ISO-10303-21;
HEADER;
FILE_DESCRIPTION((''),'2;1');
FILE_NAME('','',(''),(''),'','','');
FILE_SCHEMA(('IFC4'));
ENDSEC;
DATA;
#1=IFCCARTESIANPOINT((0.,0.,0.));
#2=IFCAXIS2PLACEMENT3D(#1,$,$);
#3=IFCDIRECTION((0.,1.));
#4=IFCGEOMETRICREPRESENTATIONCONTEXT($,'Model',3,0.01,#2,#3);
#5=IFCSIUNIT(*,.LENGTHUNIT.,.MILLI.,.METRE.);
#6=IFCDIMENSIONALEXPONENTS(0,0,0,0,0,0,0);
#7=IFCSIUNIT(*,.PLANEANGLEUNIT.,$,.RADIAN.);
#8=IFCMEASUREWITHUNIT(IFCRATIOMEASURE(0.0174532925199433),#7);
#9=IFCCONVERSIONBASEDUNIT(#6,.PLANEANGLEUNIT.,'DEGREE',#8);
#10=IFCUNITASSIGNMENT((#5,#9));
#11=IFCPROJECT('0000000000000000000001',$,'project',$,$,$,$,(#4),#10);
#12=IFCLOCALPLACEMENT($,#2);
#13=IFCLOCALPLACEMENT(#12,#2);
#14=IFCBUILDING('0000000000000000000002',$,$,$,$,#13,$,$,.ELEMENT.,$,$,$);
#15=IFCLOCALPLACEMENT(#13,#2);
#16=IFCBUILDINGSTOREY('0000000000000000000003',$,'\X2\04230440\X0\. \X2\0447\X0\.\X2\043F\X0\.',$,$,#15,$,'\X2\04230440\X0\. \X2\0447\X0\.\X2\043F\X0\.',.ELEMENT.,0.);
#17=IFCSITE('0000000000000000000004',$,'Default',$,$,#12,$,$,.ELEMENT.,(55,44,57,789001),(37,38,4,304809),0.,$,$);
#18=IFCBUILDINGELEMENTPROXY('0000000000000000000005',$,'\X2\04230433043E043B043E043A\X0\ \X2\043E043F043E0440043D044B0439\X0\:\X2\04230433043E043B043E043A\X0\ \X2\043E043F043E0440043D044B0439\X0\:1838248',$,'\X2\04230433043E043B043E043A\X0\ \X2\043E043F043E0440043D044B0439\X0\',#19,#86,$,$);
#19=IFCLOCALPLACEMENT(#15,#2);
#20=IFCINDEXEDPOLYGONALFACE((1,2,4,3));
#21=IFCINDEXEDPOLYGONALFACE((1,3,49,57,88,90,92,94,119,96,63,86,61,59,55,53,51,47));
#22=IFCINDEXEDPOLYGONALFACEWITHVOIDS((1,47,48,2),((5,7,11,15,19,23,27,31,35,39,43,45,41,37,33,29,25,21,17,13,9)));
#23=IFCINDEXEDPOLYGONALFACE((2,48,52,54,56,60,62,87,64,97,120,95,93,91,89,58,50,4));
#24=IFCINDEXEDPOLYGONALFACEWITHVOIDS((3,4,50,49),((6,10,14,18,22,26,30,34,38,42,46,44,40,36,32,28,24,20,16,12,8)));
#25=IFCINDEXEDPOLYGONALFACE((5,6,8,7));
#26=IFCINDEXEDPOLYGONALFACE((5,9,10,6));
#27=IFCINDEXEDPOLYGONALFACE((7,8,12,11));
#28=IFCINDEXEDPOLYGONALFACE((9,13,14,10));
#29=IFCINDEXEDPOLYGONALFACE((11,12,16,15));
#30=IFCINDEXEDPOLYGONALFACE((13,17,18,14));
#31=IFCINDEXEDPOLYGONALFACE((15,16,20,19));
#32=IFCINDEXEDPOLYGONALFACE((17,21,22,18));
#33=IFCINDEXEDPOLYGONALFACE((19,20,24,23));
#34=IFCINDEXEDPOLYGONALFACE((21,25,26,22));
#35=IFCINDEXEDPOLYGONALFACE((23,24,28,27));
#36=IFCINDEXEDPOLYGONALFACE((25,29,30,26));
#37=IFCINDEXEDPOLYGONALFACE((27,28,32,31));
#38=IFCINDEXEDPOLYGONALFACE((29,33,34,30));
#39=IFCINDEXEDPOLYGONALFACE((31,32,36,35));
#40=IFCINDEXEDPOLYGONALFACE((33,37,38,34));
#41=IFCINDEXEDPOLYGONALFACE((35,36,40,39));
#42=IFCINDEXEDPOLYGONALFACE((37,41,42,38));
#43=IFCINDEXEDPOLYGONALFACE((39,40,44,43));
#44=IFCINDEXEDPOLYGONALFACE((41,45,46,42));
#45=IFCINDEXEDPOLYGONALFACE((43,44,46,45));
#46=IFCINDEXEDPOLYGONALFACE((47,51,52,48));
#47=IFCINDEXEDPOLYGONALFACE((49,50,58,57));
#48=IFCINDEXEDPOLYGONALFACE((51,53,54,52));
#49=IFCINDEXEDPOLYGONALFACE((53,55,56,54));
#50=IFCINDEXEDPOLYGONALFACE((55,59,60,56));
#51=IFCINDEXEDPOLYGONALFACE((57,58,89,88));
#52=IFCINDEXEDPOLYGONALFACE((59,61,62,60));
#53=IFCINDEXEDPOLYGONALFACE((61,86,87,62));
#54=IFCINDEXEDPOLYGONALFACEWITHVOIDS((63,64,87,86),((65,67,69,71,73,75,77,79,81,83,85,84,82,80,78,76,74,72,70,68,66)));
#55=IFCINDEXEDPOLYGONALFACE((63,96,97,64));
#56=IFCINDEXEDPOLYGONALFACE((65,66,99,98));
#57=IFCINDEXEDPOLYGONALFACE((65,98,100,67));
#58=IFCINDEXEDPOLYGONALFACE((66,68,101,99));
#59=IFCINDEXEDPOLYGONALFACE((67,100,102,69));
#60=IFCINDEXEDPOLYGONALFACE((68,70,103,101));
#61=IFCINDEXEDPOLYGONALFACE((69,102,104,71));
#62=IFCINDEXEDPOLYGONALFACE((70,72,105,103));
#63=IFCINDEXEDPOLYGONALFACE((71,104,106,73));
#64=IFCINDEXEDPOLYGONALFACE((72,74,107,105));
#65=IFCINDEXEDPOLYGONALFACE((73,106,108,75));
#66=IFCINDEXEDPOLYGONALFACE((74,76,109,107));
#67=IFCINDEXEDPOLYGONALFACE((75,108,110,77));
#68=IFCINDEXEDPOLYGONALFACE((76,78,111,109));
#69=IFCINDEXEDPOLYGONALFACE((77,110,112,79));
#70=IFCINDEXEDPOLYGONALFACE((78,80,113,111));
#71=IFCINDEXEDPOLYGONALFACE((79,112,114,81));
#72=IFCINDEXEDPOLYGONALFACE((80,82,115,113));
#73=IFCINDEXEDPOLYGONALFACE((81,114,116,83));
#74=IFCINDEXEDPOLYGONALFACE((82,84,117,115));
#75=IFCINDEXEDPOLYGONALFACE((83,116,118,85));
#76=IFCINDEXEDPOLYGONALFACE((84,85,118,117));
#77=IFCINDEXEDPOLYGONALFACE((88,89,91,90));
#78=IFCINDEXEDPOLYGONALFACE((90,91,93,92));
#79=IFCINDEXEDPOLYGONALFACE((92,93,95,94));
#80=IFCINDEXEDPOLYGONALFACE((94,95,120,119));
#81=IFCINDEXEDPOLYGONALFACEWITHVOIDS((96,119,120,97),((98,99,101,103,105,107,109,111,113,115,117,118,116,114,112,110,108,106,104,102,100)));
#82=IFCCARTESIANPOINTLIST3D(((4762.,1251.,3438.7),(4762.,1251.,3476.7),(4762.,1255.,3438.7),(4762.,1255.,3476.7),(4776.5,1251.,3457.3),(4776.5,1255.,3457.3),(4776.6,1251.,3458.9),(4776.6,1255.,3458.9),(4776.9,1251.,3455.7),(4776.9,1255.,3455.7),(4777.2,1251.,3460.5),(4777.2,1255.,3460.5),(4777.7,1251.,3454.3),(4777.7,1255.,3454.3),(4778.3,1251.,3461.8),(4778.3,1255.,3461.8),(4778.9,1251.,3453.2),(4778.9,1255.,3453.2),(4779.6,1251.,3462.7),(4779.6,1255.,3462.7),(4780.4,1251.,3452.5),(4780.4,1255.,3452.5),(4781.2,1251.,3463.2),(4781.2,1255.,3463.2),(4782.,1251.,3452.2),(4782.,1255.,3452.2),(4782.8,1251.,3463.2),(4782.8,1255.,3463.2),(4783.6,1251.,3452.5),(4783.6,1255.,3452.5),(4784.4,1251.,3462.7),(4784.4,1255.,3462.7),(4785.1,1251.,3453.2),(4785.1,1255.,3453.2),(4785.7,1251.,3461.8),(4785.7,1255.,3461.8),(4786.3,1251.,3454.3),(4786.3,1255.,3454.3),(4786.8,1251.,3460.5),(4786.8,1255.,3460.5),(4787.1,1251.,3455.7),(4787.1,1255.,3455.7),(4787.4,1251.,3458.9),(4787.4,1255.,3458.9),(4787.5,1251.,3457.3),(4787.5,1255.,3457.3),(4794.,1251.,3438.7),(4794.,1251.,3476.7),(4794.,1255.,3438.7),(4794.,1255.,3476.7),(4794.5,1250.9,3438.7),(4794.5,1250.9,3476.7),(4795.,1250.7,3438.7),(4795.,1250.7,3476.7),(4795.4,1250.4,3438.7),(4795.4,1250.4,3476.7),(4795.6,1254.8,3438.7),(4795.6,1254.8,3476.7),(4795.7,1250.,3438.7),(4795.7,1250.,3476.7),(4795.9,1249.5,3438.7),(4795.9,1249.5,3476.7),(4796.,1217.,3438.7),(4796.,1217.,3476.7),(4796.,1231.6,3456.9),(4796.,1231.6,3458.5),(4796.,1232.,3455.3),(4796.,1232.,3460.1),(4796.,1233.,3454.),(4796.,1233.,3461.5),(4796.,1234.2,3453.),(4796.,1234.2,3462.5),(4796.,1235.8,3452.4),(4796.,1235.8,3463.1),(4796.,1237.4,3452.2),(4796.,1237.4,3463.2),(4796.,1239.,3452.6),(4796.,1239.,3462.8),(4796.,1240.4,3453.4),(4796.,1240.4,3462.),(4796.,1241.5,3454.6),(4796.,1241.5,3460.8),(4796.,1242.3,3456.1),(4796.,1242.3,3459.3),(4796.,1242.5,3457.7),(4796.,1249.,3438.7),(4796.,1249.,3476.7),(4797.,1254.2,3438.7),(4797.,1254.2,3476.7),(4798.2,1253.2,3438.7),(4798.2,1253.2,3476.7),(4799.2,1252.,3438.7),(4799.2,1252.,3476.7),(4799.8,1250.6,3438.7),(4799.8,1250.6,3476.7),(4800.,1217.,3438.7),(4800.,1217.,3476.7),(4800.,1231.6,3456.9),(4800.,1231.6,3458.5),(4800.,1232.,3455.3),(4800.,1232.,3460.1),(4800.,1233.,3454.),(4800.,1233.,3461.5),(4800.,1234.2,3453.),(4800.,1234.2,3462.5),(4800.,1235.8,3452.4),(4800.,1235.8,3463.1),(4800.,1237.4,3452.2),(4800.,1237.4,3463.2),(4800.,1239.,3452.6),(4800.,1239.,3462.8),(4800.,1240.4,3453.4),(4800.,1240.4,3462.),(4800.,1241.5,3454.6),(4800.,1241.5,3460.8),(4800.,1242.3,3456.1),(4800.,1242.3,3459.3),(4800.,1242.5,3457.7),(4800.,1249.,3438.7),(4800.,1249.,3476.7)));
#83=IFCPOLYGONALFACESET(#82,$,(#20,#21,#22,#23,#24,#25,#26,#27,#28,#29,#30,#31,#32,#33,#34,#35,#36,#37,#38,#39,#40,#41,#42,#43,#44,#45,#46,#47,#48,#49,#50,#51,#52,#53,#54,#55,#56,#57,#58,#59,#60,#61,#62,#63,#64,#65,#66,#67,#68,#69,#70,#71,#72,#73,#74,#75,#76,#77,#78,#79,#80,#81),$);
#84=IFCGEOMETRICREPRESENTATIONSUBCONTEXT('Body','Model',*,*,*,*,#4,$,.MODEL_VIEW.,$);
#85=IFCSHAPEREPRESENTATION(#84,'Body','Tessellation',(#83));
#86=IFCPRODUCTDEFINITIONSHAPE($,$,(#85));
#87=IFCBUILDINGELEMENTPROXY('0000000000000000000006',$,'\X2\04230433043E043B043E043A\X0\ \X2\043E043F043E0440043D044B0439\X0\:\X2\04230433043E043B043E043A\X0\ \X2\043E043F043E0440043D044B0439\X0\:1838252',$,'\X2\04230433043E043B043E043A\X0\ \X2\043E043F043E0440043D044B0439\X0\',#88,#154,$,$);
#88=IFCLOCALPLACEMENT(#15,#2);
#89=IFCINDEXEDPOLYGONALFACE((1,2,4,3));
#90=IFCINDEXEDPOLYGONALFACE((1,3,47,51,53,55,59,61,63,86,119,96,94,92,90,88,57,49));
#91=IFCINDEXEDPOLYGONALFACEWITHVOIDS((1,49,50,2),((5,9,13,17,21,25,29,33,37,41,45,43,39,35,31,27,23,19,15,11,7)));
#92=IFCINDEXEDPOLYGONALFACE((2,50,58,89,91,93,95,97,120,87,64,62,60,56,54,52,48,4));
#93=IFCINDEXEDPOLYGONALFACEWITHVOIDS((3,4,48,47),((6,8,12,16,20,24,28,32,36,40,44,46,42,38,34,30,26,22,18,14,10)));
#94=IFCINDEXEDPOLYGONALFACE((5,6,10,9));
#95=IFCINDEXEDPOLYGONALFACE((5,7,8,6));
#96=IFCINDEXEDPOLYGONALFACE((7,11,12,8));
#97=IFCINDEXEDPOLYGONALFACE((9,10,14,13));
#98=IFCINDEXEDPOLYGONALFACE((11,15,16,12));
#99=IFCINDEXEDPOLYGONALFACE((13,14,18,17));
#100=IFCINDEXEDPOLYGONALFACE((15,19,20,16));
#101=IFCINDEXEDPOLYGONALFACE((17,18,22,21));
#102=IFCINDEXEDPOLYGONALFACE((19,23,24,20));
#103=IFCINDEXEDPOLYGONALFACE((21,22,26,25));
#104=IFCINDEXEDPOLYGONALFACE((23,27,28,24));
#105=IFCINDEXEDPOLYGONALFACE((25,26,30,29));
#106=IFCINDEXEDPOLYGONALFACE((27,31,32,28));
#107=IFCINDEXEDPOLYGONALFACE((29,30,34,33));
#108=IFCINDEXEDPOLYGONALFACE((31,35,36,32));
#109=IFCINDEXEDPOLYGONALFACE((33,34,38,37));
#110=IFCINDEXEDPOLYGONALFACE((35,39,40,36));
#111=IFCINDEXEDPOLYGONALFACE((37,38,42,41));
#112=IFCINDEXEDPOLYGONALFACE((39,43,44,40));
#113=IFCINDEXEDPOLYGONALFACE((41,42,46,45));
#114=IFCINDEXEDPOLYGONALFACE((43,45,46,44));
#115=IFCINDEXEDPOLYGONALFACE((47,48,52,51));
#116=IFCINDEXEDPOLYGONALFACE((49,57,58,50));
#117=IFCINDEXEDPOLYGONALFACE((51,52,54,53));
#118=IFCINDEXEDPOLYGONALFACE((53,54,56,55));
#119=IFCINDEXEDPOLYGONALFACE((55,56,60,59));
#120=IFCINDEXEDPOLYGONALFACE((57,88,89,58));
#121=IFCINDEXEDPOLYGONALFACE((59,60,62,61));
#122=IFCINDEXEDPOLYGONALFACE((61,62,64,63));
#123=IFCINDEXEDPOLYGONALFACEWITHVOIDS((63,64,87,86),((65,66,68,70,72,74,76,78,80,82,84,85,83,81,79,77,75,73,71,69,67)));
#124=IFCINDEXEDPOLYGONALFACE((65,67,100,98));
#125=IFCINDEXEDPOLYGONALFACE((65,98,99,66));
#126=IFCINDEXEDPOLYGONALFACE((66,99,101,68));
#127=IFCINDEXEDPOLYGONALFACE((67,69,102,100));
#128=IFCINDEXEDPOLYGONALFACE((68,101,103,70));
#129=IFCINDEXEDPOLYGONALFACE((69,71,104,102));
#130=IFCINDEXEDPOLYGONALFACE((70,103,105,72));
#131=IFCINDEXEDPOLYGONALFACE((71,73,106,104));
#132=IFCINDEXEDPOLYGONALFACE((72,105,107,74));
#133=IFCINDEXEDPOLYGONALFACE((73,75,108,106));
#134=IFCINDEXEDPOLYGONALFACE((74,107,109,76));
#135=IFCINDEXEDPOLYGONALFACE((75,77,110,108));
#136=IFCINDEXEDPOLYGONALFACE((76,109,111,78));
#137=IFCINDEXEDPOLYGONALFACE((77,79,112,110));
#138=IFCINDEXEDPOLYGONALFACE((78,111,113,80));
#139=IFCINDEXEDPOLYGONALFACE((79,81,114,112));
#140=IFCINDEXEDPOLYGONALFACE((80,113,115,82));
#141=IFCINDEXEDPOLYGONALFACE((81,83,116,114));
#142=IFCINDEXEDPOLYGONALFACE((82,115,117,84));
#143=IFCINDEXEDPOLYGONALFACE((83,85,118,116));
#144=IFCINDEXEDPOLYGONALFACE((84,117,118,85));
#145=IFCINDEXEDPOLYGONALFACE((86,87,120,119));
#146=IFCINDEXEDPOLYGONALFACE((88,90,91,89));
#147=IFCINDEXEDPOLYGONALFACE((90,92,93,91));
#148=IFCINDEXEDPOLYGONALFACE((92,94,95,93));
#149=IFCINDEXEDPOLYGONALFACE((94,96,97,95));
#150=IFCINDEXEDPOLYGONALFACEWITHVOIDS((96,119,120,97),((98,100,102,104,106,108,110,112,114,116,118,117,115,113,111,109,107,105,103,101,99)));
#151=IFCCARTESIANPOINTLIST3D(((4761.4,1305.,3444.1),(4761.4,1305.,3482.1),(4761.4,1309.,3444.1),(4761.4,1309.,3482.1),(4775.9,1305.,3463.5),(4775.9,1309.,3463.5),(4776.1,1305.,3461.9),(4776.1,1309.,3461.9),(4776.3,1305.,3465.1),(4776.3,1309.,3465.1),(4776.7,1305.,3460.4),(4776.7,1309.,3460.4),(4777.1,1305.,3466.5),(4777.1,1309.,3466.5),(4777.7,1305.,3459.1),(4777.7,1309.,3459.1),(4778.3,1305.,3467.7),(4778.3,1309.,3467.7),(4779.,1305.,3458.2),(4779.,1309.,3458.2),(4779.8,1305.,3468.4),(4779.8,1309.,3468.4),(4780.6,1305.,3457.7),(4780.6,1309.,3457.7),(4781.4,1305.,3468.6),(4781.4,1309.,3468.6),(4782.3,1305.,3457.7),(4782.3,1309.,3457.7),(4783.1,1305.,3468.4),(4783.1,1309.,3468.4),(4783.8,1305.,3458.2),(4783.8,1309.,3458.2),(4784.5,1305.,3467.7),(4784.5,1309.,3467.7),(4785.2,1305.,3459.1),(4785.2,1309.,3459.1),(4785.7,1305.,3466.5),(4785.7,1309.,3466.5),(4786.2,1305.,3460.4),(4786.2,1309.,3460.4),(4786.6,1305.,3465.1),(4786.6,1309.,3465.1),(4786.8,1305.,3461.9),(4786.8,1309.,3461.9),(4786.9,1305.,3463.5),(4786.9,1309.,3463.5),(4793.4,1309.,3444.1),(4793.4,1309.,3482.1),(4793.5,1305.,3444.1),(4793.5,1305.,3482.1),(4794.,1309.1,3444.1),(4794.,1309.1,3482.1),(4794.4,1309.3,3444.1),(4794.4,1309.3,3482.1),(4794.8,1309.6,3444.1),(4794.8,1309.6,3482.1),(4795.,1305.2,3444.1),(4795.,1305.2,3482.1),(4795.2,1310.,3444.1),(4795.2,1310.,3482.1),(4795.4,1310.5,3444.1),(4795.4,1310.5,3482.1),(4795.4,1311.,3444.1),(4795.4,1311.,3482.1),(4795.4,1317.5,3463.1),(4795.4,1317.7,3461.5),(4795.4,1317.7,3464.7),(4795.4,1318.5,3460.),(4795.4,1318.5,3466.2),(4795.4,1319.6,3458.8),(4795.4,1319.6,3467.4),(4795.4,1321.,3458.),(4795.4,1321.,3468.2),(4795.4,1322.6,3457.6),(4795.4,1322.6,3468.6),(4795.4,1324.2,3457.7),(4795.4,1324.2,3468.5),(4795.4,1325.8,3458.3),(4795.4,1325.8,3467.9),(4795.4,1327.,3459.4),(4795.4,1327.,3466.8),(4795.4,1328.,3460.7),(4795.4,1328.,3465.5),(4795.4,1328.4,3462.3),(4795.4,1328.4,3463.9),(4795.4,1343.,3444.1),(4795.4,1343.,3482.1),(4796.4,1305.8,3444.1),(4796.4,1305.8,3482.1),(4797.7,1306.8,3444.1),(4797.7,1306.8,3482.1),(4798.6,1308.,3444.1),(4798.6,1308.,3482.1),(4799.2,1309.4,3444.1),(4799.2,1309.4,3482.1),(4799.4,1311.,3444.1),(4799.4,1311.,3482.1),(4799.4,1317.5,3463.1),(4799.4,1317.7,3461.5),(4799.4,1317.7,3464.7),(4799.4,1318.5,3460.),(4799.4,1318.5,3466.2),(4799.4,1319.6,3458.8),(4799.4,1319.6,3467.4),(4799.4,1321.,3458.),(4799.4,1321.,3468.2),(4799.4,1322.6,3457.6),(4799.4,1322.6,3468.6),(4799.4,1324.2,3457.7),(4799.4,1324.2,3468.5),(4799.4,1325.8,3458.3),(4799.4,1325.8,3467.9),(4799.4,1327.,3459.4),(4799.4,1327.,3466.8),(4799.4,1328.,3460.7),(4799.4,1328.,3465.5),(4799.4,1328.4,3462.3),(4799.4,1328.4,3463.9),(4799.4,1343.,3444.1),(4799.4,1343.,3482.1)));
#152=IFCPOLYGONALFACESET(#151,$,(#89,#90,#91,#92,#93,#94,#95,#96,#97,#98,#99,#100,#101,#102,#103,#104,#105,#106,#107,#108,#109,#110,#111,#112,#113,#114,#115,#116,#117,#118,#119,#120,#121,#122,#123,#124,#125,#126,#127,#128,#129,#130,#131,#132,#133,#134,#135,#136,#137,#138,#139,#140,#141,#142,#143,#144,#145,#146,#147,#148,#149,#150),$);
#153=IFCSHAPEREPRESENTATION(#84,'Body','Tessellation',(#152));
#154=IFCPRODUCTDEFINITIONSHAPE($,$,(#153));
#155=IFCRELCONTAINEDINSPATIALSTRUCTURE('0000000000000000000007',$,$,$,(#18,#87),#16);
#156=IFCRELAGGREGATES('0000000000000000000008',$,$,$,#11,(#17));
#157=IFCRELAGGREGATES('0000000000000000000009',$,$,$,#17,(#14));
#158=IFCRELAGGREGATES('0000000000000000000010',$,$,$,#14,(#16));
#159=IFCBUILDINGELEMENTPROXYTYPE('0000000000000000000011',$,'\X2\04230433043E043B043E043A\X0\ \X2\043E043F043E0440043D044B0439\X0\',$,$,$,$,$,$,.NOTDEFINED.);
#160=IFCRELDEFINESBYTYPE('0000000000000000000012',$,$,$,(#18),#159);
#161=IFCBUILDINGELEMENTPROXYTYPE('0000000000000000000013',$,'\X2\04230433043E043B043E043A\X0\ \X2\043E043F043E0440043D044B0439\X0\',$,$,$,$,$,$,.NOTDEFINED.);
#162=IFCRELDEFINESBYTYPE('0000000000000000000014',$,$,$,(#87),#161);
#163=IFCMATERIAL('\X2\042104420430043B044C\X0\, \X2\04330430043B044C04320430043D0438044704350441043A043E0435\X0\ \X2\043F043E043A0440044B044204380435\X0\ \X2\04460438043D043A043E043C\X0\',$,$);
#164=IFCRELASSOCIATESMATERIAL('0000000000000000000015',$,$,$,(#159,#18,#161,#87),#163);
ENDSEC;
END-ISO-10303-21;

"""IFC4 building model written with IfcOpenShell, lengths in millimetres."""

from ifc_helpers import new_model, entity, si_unit, converted_unit, direction, frame, frame_2d, origin, place, context, subcontext, project, spatial, polyline, circle_curve, parameter, trimmed, segment, composite_curve, circle, outline, extrude, source, transform, mapped, material, type_object, type_shapes, element, save


model = new_model("IFC4")

# Units and contexts
model_context = context("Model", 3, precision=0.01, world=origin(), true_north=direction((0.0, 1.0)))
body_context = subcontext(model_context, "Body", "Model", "MODEL_VIEW")
ifc_project = project(units=[si_unit("LENGTHUNIT", "METRE", prefix="MILLI"), converted_unit("PLANEANGLEUNIT", "DEGREE", entity("IfcRatioMeasure", 0.0174532925199433), si_unit("PLANEANGLEUNIT", "RADIAN"), dimensions=[0, 0, 0, 0, 0, 0, 0])], contexts=[model_context])

# Site, building, storey
site_placement = place(None, origin())
site = spatial("IfcSite", under=ifc_project, at=site_placement, Name="Default", CompositionType="ELEMENT", RefLatitude=(55, 44, 57, 789001), RefLongitude=(37, 38, 4, 304809), RefElevation=0.0)
building_placement = place(site_placement, origin())
building = spatial("IfcBuilding", under=site, at=building_placement, CompositionType="ELEMENT")
storey_placement = place(building_placement, origin())
storey = spatial("IfcBuildingStorey", under=building, at=storey_placement, Name="Ур. ч.п.", LongName="Ур. ч.п.", CompositionType="ELEMENT", Elevation=0.0)

# Building element proxies, openings
ifc_material = material(Name="Сталь, гальваническое покрытие цинком")
building_element_proxy_type_1 = type_object("IfcBuildingElementProxyType", Name="Уголок опорный", material=ifc_material)
shared_shape_1 = source(origin(), body_context, "Body", "SweptSolid", [
    extrude(outline(composite_curve([segment(polyline([(-6.0, -12.0), (26.0, -12.0)]), True, "CONTINUOUS"), segment(polyline([(26.0, -12.0), (26.0, -8.0)]), True, "CONTINUOUS"), segment(polyline([(26.0, -8.0), (-6.0, -8.0)]), True, "CONTINUOUS"), segment(trimmed(circle_curve(frame_2d((-6.0, -6.0), x_axis=(0.0, -1.0)), 2.0), [parameter(270.0)], [parameter(0.0)], True, "PARAMETER"), False, "CONTINUOUS"), segment(polyline([(-8.0, -6.0), (-8.0, 26.0)]), True, "CONTINUOUS"), segment(polyline([(-8.0, 26.0), (-12.0, 26.0)]), True, "CONTINUOUS"), segment(polyline([(-12.0, 26.0), (-12.0, -6.0)]), True, "CONTINUOUS"), segment(trimmed(circle_curve(frame_2d((-6.0, -6.0), x_axis=(0.0, -1.0)), 6.0), [parameter(270.0)], [parameter(360.0)], True, "PARAMETER"), True, "CONTINUOUS")], self_intersect=False)), frame((12.0, -19.0, 12.0), z_axis=(0.0, 1.0, 0.0), x_axis=(0.0, 0.0, 1.0)), (0.0, 0.0, 1.0), 38.0),
])
type_shapes(building_element_proxy_type_1, [shared_shape_1])
proxy_1_placement = place(storey_placement, frame((4800.0, 1255.0, 3457.7), z_axis=(0.0, -1.0, 0.0), x_axis=(-1.0, 0.0, 0.0)))
proxy_1 = element("IfcBuildingElementProxy", 1, at=proxy_1_placement, inside=storey, type_object=building_element_proxy_type_1, material=ifc_material, Name="Уголок опорный:Уголок опорный:1838248", ObjectType="Уголок опорный", context=body_context, shape_type="MappedRepresentation", body=[
    mapped(shared_shape_1, transform((0.0, 0.0, 0.0), scale=1.0)),
])
opening_1_placement = place(storey_placement, frame((4800.0, 1255.0, 3457.7)))
element("IfcOpeningElement", 2, at=opening_1_placement, cuts=proxy_1, ObjectType="Opening", PredefinedType="OPENING", context=body_context, shape_type="SweptSolid", body=[
    extrude(circle(Radius=5.5, at=frame_2d((0.0, 0.0), x_axis=(1.0, 0.0))), frame((-4.0, -18.0, 0.0), z_axis=(1.0, 0.0, 0.0), x_axis=(0.0, 1.0, 0.0)), (0.0, 0.0, 1.0), 4.0),
])
opening_2_placement = place(storey_placement, frame((4800.0, 1255.0, 3457.7)))
element("IfcOpeningElement", 3, at=opening_2_placement, cuts=proxy_1, ObjectType="Opening", PredefinedType="OPENING", context=body_context, shape_type="SweptSolid", body=[
    extrude(circle(Radius=5.5, at=frame_2d((0.0, 0.0), x_axis=(1.0, 0.0))), frame((-18.0, 0.0, 0.0), z_axis=(0.0, -1.0, 0.0), x_axis=(0.0, 0.0, -1.0)), (0.0, 0.0, 1.0), 4.0),
])
building_element_proxy_type_2 = type_object("IfcBuildingElementProxyType", Name="Уголок опорный", material=ifc_material)
shared_shape_2 = source(origin(), body_context, "Body", "SweptSolid", [
    extrude(outline(composite_curve([segment(polyline([(-6.0, -12.0), (26.0, -12.0)]), True, "CONTINUOUS"), segment(polyline([(26.0, -12.0), (26.0, -8.0)]), True, "CONTINUOUS"), segment(polyline([(26.0, -8.0), (-6.0, -8.0)]), True, "CONTINUOUS"), segment(trimmed(circle_curve(frame_2d((-6.0, -6.0), x_axis=(0.0, -1.0)), 2.0), [parameter(270.0)], [parameter(0.0)], True, "PARAMETER"), False, "CONTINUOUS"), segment(polyline([(-8.0, -6.0), (-8.0, 26.0)]), True, "CONTINUOUS"), segment(polyline([(-8.0, 26.0), (-12.0, 26.0)]), True, "CONTINUOUS"), segment(polyline([(-12.0, 26.0), (-12.0, -6.0)]), True, "CONTINUOUS"), segment(trimmed(circle_curve(frame_2d((-6.0, -6.0), x_axis=(0.0, -1.0)), 6.0), [parameter(270.0)], [parameter(360.0)], True, "PARAMETER"), True, "CONTINUOUS")], self_intersect=False)), frame((12.0, -19.0, 12.0), z_axis=(0.0, 1.0, 0.0), x_axis=(0.0, 0.0, 1.0)), (0.0, 0.0, 1.0), 38.0),
])
type_shapes(building_element_proxy_type_2, [shared_shape_2])
proxy_2_placement = place(storey_placement, frame((4799.4, 1305.0, 3463.1), z_axis=(0.0, 1.0, 0.0), x_axis=(-1.0, 0.0, 0.0)))
proxy_2 = element("IfcBuildingElementProxy", 4, at=proxy_2_placement, inside=storey, type_object=building_element_proxy_type_2, material=ifc_material, Name="Уголок опорный:Уголок опорный:1838252", ObjectType="Уголок опорный", context=body_context, shape_type="MappedRepresentation", body=[
    mapped(shared_shape_2, transform((0.0, 0.0, 0.0), scale=1.0)),
])
opening_3_placement = place(storey_placement, frame((4799.4, 1305.0, 3463.1)))
element("IfcOpeningElement", 5, at=opening_3_placement, cuts=proxy_2, ObjectType="Opening", PredefinedType="OPENING", context=body_context, shape_type="SweptSolid", body=[
    extrude(circle(Radius=5.5, at=frame_2d((0.0, 0.0), x_axis=(1.0, 0.0))), frame((-4.0, 18.0, 0.0), z_axis=(1.0, 0.0, 0.0), x_axis=(0.0, -1.0, 0.0)), (0.0, 0.0, 1.0), 4.0),
])
opening_4_placement = place(storey_placement, frame((4799.4, 1305.0, 3463.1)))
element("IfcOpeningElement", 6, at=opening_4_placement, cuts=proxy_2, ObjectType="Opening", PredefinedType="OPENING", context=body_context, shape_type="SweptSolid", body=[
    extrude(circle(Radius=5.5, at=frame_2d((0.0, 0.0), x_axis=(1.0, 0.0))), frame((-18.0, 0.0, 0.0), z_axis=(0.0, 1.0, 0.0), x_axis=(0.0, 0.0, 1.0)), (0.0, 0.0, 1.0), 4.0),
])

save(model, "model.ifc")
